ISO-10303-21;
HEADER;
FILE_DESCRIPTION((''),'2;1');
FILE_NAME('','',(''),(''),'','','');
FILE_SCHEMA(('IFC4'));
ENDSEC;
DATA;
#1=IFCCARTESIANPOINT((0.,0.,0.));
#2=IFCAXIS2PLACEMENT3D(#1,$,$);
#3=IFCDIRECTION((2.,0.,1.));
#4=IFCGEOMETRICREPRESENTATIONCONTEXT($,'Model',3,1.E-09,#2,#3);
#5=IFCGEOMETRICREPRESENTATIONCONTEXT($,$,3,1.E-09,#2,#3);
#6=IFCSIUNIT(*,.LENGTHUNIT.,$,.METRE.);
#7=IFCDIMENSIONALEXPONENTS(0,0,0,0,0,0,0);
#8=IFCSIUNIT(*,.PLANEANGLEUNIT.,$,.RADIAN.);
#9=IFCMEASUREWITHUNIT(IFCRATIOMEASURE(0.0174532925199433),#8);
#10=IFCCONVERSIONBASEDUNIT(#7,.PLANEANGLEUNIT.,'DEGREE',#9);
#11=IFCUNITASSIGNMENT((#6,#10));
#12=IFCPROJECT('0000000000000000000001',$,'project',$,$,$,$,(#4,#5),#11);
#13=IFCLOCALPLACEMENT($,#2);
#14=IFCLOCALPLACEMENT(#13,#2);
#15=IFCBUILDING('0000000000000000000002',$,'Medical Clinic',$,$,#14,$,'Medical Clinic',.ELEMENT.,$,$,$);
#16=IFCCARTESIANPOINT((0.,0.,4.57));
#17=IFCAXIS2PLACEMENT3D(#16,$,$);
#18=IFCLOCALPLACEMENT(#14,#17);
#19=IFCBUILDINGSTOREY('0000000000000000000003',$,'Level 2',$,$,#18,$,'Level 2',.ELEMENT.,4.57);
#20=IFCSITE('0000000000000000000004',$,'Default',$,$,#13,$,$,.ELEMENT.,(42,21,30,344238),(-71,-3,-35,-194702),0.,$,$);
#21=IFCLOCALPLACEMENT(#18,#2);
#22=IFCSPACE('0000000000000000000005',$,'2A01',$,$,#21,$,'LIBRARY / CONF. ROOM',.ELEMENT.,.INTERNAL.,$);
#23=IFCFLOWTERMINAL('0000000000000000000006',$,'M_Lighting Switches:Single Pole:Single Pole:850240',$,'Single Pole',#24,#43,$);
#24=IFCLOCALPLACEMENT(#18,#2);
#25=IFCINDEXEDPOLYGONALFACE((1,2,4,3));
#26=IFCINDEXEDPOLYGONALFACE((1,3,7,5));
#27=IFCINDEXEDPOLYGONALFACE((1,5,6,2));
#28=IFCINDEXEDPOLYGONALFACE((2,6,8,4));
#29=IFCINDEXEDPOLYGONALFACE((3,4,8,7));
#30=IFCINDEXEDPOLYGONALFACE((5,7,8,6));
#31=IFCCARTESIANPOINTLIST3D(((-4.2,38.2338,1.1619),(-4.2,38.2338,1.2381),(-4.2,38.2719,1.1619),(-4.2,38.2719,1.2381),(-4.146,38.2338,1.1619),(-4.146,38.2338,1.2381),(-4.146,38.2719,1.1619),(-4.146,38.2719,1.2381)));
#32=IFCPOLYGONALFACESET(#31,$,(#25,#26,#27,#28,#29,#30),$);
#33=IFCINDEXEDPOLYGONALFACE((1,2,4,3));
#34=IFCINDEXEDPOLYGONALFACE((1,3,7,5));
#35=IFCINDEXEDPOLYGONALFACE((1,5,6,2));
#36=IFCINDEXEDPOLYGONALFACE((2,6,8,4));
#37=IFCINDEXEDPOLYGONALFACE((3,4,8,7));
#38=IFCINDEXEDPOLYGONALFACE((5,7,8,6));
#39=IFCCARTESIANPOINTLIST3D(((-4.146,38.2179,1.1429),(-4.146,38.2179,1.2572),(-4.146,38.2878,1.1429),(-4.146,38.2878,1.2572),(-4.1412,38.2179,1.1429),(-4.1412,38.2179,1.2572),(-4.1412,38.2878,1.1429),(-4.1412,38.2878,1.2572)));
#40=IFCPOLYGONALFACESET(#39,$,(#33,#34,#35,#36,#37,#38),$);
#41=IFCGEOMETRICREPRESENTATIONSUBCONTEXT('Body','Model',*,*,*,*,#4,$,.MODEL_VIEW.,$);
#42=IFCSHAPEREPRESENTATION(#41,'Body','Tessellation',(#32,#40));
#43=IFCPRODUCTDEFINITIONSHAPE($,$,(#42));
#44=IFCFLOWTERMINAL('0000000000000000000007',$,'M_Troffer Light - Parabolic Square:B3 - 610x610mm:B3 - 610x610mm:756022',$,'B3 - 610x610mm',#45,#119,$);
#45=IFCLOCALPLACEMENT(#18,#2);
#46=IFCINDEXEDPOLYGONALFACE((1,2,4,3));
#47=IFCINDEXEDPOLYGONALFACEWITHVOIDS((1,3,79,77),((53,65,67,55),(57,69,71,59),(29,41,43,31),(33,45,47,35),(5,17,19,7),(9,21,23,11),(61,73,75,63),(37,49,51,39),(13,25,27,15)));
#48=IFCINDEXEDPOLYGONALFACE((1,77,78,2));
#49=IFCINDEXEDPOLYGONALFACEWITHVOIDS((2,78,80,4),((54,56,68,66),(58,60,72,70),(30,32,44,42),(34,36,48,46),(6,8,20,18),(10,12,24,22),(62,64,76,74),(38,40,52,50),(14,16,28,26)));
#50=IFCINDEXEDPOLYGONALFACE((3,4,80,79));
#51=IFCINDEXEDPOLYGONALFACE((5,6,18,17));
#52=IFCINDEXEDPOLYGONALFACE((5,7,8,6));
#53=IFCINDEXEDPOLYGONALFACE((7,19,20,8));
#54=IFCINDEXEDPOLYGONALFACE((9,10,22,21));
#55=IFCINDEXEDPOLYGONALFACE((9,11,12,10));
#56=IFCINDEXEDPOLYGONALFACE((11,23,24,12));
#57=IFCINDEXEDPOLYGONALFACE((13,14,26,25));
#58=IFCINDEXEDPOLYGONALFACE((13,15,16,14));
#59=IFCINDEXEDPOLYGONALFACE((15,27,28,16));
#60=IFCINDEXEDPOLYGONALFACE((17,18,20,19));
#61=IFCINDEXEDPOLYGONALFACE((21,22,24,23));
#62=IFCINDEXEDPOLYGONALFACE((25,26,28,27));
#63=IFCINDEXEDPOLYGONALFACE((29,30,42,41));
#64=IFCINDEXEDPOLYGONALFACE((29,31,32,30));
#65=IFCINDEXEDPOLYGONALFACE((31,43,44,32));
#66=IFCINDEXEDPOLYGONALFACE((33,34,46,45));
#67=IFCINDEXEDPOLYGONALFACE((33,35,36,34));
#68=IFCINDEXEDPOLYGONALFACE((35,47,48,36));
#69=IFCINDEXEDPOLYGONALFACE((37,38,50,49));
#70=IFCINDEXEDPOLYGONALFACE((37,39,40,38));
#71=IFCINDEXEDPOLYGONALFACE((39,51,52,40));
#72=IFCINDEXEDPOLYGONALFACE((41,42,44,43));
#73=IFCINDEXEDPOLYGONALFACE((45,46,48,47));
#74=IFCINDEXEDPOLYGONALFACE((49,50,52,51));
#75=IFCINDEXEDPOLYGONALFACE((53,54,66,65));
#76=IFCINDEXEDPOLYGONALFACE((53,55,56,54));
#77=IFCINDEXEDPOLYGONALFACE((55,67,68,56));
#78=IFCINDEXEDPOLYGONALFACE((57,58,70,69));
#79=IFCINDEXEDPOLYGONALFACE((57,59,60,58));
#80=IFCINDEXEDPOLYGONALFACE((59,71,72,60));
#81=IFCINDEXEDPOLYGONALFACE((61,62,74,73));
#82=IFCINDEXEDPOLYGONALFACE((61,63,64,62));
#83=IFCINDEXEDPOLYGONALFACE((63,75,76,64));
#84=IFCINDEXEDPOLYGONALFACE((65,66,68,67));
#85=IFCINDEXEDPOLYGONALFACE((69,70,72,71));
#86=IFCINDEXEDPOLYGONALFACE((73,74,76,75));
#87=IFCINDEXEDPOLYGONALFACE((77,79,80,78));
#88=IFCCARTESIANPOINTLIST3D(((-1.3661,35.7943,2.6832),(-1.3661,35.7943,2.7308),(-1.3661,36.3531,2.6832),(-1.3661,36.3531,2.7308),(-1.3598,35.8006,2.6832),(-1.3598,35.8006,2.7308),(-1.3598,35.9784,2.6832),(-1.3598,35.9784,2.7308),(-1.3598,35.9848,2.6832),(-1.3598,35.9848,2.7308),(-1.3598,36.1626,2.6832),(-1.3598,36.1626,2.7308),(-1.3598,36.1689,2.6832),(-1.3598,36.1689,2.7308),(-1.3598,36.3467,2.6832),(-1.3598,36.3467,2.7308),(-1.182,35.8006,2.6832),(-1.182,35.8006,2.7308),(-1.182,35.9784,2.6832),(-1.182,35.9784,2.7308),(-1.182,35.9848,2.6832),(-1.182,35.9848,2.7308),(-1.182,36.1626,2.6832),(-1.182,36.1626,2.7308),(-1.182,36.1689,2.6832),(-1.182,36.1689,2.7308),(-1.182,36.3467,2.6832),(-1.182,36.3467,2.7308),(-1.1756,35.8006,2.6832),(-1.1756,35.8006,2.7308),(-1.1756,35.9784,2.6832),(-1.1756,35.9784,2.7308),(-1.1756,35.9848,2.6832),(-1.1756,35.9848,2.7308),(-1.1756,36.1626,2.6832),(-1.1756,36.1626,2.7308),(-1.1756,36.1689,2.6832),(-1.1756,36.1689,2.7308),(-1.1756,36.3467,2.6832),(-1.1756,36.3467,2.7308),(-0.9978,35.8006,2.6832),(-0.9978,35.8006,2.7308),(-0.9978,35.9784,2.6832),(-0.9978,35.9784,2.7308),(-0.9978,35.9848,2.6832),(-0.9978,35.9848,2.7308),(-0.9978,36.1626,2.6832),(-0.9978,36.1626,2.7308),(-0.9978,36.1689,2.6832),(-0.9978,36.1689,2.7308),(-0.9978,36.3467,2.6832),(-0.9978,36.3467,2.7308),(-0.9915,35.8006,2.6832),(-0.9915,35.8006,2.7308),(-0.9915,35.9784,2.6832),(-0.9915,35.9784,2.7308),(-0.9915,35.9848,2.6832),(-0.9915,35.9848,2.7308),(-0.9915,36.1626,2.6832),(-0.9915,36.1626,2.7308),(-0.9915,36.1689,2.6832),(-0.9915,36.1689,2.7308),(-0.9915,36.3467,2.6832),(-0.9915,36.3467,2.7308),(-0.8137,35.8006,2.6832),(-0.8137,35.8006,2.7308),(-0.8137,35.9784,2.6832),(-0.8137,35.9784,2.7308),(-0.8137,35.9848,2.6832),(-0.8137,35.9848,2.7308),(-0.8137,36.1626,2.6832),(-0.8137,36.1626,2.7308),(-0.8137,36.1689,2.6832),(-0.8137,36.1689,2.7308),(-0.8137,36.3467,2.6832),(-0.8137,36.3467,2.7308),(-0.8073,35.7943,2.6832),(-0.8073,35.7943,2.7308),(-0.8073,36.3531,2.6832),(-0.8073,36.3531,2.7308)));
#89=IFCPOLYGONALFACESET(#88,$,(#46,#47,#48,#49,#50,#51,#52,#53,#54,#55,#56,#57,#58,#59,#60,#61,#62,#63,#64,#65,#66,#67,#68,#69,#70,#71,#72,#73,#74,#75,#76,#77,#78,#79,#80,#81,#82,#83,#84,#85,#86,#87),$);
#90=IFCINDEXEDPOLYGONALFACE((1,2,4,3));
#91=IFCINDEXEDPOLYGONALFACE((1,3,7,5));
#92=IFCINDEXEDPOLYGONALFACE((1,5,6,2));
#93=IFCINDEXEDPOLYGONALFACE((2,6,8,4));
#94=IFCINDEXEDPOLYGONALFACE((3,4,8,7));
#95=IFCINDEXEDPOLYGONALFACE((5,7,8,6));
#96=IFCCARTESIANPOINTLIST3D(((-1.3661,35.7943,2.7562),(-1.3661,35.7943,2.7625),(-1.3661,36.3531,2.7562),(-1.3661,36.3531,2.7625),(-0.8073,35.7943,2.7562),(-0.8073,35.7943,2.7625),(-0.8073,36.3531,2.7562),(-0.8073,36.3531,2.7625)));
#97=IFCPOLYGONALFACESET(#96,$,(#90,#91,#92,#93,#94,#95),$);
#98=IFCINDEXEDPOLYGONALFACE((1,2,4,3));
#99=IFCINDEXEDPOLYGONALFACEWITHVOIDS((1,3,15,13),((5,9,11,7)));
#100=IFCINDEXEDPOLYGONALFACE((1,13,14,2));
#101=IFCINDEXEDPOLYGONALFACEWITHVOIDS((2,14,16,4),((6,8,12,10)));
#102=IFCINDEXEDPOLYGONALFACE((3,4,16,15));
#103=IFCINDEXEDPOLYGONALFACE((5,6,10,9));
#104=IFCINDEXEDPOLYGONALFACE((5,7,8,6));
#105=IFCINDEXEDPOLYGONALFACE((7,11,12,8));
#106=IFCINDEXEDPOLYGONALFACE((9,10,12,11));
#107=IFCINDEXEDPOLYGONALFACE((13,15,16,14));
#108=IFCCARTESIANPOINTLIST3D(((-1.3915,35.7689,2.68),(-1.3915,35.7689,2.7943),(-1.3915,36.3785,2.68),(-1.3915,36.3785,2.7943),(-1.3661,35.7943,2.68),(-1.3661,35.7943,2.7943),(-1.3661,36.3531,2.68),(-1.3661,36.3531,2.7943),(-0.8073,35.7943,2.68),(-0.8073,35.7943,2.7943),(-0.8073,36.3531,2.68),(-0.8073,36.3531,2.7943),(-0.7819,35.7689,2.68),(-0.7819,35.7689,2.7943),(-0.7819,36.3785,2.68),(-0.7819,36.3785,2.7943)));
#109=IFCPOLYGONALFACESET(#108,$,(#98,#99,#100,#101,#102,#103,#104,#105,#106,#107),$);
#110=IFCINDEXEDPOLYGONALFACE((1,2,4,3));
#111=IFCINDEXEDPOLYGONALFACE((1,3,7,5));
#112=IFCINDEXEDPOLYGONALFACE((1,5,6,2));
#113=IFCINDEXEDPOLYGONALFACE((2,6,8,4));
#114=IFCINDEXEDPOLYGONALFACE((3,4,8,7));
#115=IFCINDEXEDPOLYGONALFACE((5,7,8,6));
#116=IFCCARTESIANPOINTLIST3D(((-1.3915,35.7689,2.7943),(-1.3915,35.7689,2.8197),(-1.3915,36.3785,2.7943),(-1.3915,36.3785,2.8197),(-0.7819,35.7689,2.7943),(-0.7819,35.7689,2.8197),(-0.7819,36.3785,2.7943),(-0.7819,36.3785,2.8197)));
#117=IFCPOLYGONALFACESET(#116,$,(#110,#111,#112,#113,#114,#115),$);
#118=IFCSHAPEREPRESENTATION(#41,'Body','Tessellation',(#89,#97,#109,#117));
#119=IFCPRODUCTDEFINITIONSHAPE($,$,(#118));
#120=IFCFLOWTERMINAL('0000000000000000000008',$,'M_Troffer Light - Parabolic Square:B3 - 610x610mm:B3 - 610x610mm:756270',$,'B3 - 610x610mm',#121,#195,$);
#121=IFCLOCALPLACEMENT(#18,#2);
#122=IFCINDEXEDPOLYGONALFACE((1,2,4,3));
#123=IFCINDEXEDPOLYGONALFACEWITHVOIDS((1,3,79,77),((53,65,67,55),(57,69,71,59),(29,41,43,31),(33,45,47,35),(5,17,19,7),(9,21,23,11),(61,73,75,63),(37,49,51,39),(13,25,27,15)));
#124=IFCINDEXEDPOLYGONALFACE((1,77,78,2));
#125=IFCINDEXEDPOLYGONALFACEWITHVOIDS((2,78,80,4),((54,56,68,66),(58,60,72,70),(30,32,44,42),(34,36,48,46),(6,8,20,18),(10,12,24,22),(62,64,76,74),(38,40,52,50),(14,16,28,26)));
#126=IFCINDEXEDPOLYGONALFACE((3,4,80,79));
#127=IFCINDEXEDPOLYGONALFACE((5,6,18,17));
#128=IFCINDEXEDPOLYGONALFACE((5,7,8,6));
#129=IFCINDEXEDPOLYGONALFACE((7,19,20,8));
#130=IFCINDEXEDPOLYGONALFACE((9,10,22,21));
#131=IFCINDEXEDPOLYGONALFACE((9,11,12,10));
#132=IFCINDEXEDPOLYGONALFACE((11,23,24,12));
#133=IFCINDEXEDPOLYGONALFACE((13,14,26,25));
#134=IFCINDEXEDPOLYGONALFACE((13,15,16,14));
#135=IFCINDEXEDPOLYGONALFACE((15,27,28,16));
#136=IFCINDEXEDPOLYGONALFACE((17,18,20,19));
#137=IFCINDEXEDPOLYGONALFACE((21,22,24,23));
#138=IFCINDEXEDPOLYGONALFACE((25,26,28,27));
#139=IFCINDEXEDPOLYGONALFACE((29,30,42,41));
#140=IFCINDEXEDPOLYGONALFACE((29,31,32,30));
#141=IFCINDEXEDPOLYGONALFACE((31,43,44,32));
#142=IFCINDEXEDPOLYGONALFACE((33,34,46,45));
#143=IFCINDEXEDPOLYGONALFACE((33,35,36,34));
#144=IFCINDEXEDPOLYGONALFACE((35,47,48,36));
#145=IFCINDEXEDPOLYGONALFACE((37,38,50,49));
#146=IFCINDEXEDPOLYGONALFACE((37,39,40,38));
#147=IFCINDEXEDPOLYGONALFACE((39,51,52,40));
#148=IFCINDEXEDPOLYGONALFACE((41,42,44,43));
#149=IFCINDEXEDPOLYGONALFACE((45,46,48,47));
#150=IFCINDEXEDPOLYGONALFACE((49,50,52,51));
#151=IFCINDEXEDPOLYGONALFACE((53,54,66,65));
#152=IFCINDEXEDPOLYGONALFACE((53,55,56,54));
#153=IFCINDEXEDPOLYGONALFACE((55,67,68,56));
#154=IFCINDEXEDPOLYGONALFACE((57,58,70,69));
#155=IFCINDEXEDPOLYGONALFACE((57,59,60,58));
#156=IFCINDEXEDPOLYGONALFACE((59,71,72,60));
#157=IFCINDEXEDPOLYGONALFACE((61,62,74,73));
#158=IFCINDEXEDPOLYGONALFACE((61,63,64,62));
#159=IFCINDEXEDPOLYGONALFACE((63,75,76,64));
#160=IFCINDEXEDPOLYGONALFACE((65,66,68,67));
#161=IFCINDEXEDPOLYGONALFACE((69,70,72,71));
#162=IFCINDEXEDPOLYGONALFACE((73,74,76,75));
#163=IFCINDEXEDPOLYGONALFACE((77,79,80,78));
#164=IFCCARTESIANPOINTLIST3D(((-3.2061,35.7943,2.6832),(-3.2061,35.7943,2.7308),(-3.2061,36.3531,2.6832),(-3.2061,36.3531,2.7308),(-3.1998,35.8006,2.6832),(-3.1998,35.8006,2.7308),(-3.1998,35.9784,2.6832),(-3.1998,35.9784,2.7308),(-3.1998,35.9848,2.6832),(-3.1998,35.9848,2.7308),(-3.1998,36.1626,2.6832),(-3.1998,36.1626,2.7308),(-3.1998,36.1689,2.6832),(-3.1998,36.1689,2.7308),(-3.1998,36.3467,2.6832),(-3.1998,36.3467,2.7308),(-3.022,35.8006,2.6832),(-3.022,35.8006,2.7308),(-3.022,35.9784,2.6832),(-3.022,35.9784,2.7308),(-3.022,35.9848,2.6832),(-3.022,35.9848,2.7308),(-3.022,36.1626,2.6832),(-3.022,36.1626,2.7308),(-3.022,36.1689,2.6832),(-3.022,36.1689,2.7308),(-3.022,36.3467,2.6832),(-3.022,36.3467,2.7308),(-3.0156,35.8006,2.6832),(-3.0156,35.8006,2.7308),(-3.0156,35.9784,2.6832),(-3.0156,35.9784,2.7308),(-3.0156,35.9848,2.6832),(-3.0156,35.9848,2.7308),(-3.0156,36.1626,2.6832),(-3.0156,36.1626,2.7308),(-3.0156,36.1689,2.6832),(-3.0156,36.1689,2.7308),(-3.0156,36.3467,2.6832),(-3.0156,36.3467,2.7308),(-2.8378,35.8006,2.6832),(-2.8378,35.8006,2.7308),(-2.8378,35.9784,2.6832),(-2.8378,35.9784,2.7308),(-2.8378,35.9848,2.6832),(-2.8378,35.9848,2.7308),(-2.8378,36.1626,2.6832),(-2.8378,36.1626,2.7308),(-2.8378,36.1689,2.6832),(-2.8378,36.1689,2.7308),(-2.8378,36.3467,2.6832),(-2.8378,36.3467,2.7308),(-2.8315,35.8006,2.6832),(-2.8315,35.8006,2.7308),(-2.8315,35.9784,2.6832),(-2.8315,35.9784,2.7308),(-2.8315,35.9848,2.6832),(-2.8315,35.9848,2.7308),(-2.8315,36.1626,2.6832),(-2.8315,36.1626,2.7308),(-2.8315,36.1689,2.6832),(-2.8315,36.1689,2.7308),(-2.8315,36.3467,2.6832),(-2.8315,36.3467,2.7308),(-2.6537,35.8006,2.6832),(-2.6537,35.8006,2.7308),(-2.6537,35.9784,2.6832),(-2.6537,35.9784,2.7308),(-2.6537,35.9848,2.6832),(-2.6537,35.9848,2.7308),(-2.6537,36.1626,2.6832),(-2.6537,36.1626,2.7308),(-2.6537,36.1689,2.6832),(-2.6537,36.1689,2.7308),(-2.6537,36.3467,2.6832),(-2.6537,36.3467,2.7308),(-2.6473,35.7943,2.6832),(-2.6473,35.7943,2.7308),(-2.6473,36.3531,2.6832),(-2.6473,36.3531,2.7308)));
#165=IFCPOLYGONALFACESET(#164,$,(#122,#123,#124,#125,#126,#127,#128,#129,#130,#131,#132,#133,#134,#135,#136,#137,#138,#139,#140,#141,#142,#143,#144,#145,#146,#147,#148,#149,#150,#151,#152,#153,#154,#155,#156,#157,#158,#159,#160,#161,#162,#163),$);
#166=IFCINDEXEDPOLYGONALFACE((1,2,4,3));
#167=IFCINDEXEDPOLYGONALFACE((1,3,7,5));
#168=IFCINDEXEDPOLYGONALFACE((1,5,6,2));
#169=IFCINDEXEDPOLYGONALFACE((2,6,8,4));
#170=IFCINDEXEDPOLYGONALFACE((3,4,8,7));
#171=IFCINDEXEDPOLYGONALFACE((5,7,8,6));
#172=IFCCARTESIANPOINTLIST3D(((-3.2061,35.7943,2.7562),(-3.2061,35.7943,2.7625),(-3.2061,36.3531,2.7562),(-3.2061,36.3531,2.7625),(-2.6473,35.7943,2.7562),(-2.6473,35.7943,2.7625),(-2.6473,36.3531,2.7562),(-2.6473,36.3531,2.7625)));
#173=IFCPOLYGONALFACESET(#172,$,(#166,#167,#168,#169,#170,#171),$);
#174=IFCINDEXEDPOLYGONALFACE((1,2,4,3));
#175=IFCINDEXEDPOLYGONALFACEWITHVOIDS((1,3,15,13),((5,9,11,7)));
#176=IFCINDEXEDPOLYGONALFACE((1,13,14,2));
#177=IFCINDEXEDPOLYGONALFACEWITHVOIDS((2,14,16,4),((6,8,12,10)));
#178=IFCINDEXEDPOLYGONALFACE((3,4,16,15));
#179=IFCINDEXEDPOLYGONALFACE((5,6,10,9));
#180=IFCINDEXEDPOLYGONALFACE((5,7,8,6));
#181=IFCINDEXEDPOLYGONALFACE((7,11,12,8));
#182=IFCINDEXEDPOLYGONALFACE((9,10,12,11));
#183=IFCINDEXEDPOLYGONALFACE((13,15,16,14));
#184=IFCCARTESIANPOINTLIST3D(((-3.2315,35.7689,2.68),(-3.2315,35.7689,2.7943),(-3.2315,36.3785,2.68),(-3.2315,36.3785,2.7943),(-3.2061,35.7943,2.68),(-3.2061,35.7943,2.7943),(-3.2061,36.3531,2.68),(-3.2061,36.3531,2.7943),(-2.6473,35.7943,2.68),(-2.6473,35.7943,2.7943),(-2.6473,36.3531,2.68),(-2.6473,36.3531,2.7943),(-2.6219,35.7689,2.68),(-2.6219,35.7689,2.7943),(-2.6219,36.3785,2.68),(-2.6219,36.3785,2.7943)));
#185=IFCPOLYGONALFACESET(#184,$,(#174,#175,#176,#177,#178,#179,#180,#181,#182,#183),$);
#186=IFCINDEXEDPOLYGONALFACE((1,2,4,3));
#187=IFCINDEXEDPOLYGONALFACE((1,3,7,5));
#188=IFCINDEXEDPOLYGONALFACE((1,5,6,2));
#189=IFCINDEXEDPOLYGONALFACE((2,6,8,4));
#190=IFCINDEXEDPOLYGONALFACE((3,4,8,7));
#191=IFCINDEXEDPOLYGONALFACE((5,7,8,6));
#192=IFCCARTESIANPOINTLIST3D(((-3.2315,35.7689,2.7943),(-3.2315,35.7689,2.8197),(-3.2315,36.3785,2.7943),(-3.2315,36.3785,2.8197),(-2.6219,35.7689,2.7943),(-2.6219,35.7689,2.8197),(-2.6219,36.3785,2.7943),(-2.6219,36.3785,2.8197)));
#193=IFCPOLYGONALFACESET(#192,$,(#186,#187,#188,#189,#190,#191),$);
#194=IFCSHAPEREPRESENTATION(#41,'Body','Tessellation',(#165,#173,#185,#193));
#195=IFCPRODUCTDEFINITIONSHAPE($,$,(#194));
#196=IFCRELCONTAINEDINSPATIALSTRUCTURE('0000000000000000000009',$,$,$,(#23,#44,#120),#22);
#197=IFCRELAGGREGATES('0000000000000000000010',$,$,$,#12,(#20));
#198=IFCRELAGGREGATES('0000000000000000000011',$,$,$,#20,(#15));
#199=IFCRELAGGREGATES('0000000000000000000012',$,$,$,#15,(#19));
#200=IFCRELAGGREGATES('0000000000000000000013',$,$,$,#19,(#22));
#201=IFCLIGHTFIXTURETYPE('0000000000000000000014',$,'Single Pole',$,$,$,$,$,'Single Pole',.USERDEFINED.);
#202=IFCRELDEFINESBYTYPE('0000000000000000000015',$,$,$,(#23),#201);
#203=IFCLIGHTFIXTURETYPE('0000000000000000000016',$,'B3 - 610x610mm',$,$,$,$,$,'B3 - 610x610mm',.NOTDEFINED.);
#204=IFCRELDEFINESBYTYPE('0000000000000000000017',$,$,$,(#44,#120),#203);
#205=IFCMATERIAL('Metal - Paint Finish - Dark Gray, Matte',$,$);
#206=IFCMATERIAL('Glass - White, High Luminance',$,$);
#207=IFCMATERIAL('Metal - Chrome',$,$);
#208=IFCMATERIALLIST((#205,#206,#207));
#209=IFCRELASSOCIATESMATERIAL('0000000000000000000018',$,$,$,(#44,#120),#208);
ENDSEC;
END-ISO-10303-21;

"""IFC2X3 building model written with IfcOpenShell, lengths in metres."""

from ifc_helpers import new_model, entity, si_unit, converted_unit, direction, frame, frame_2d, origin, origin_2d_with_axis, place, context, subcontext, project, spatial, polyline, rectangle, outline, extrude, source, transform, mapped, material, material_list, type_object, type_shapes, element, save


model = new_model("IFC2X3")

# Units and contexts
model_context = context("Model", 3, precision=1e-09, world=origin(), true_north=direction((2.0, 0.0, 1.0)))
context_of_model = context(None, 3, precision=1e-09, world=origin(), true_north=direction((2.0, 0.0, 1.0)))
body_context = subcontext(model_context, "Body", "Model", "MODEL_VIEW")
ifc_project = project(units=[si_unit("LENGTHUNIT", "METRE"), converted_unit("PLANEANGLEUNIT", "DEGREE", entity("IfcRatioMeasure", 0.0174532925199433), si_unit("PLANEANGLEUNIT", "RADIAN"), dimensions=[0, 0, 0, 0, 0, 0, 0])], contexts=[model_context, context_of_model])

# Site, building, storey
site_placement = place(None, origin())
site = spatial("IfcSite", under=ifc_project, at=site_placement, Name="Default", CompositionType="ELEMENT", RefLatitude=(42, 21, 30, 344238), RefLongitude=(-71, -3, -35, -194702), RefElevation=0.0)
building_placement = place(site_placement, origin())
building = spatial("IfcBuilding", under=site, at=building_placement, Name="Medical Clinic", LongName="Medical Clinic", CompositionType="ELEMENT")
storey_placement = place(building_placement, frame((0.0, 0.0, 4.57)))
storey = spatial("IfcBuildingStorey", under=building, at=storey_placement, Name="Level 2", LongName="Level 2", CompositionType="ELEMENT", Elevation=4.57)

# Shared definitions
space_1_placement = place(storey_placement, origin())
space_1 = spatial("IfcSpace", under=storey, at=space_1_placement, Name="2A01", LongName="LIBRARY / CONF. ROOM", CompositionType="ELEMENT", InteriorOrExteriorSpace="INTERNAL")

# Flow terminals
light_fixture_type_1 = type_object("IfcLightFixtureType", Name="Single Pole", ElementType="Single Pole", PredefinedType="USERDEFINED")
shared_shape_1 = source(origin(), body_context, "Body", "SweptSolid", [
    extrude(rectangle(XDim=0.0381, YDim=0.0762, at=origin_2d_with_axis()), frame((0.0, 0.0, -0.054), z_axis=(0.0, 0.0, 1.0), x_axis=(-1.0, 0.0, 0.0)), (0.0, 0.0, 1.0), 0.054),
    extrude(rectangle(XDim=0.0698, YDim=0.1143, at=frame_2d((0.0, 0.0), x_axis=(1.0, 0.0))), frame((0.0, 0.0, 0.0), z_axis=(0.0, 0.0, 1.0), x_axis=(-1.0, 0.0, 0.0)), (0.0, 0.0, 1.0), 0.0048),
])
type_shapes(light_fixture_type_1, [shared_shape_1])
for number, where, z_axis, x_axis, name in (
    (1, (-4.146, 38.2528, 1.2), (1.0, 0.0, 0.0), (0.0, 1.0, 0.0), "M_Lighting Switches:Single Pole:Single Pole:850240"),
):
    element("IfcFlowTerminal", number, at=place(space_1_placement, frame(where, z_axis=z_axis, x_axis=x_axis)), inside=space_1, type_object=light_fixture_type_1, Name=name, ObjectType="Single Pole", context=body_context, shape_type="MappedRepresentation", body=[
        mapped(shared_shape_1, transform((0.0, 0.0, 0.0), scale=1.0)),
    ])
ifc_material_1 = material(Name="Metal - Paint Finish - Dark Gray, Matte")
ifc_material_2 = material(Name="Glass - White, High Luminance")
ifc_material_3 = material(Name="Metal - Chrome")
ifc_material_list = material_list([ifc_material_1, ifc_material_2, ifc_material_3])
light_fixture_type_2 = type_object("IfcLightFixtureType", Name="B3 - 610x610mm", ElementType="B3 - 610x610mm", PredefinedType="NOTDEFINED")
shared_shape_2 = source(origin(), body_context, "Body", "SweptSolid", [
    extrude(outline(polyline([(-0.2794, -0.2794), (0.2794, -0.2794), (0.2794, 0.2794), (-0.2794, 0.2794), (-0.2794, -0.2794)]), holes=[polyline([(-0.0952, 0.0953), (-0.273, 0.0953), (-0.273, 0.2731), (-0.0952, 0.2731), (-0.0952, 0.0953)]), polyline([(0.2731, 0.0953), (0.0953, 0.0953), (0.0953, 0.2731), (0.2731, 0.2731), (0.2731, 0.0953)]), polyline([(-0.0889, 0.2731), (0.0889, 0.2731), (0.0889, 0.0953), (-0.0889, 0.0953), (-0.0889, 0.2731)]), polyline([(0.2731, -0.273), (0.0953, -0.273), (0.0953, -0.0952), (0.2731, -0.0952), (0.2731, -0.273)]), polyline([(0.0889, -0.273), (-0.0889, -0.273), (-0.0889, -0.0952), (0.0889, -0.0952), (0.0889, -0.273)]), polyline([(-0.0952, -0.273), (-0.273, -0.273), (-0.273, -0.0952), (-0.0952, -0.0952), (-0.0952, -0.273)]), polyline([(-0.0952, -0.0889), (-0.273, -0.0889), (-0.273, 0.0889), (-0.0952, 0.0889), (-0.0952, -0.0889)]), polyline([(0.0889, -0.0889), (-0.0889, -0.0889), (-0.0889, 0.0889), (0.0889, 0.0889), (0.0889, -0.0889)]), polyline([(0.2731, -0.0889), (0.0953, -0.0889), (0.0953, 0.0889), (0.2731, 0.0889), (0.2731, -0.0889)])]), frame((0.0, -0.3048, -0.0508), z_axis=(0.0, 0.0, 1.0), x_axis=(-1.0, 0.0, 0.0)), (0.0, 0.0, 1.0), 0.0476),
    extrude(rectangle(XDim=0.5588, YDim=0.5588, at=origin_2d_with_axis()), frame((0.0, -0.3048, -0.0825), z_axis=(0.0, 0.0, 1.0), x_axis=(-1.0, 0.0, 0.0)), (0.0, 0.0, 1.0), 0.0064),
    extrude(outline(polyline([(-0.3048, -0.3048), (0.3048, -0.3048), (0.3048, 0.3048), (-0.3048, 0.3048), (-0.3048, -0.3048)]), holes=[polyline([(0.2794, 0.2794), (0.2794, -0.2794), (-0.2794, -0.2794), (-0.2794, 0.2794), (0.2794, 0.2794)])]), frame((0.0, -0.3048, -0.1143)), (0.0, 0.0, 1.0), 0.1143),
    extrude(rectangle(XDim=0.6096, YDim=0.6096, at=origin_2d_with_axis()), frame((0.0, -0.3048, -0.1397), z_axis=(0.0, 0.0, 1.0), x_axis=(-1.0, 0.0, 0.0)), (0.0, 0.0, 1.0), 0.0254),
])
type_shapes(light_fixture_type_2, [shared_shape_2])
for number, where, z_axis, x_axis, name in (
    (2, (-1.0867, 35.7689, 2.68), (0.0, 0.0, -1.0), (1.0, 0.0, 0.0), "M_Troffer Light - Parabolic Square:B3 - 610x610mm:B3 - 610x610mm:756022"),
    (3, (-2.9267, 35.7689, 2.68), (0.0, 0.0, -1.0), (1.0, 0.0, 0.0), "M_Troffer Light - Parabolic Square:B3 - 610x610mm:B3 - 610x610mm:756270"),
):
    element("IfcFlowTerminal", number, at=place(space_1_placement, frame(where, z_axis=z_axis, x_axis=x_axis)), inside=space_1, type_object=light_fixture_type_2, material=ifc_material_list, Name=name, ObjectType="B3 - 610x610mm", context=body_context, shape_type="MappedRepresentation", body=[
        mapped(shared_shape_2, transform((0.0, 0.0, 0.0), scale=1.0)),
    ])

save(model, "model.ifc")
